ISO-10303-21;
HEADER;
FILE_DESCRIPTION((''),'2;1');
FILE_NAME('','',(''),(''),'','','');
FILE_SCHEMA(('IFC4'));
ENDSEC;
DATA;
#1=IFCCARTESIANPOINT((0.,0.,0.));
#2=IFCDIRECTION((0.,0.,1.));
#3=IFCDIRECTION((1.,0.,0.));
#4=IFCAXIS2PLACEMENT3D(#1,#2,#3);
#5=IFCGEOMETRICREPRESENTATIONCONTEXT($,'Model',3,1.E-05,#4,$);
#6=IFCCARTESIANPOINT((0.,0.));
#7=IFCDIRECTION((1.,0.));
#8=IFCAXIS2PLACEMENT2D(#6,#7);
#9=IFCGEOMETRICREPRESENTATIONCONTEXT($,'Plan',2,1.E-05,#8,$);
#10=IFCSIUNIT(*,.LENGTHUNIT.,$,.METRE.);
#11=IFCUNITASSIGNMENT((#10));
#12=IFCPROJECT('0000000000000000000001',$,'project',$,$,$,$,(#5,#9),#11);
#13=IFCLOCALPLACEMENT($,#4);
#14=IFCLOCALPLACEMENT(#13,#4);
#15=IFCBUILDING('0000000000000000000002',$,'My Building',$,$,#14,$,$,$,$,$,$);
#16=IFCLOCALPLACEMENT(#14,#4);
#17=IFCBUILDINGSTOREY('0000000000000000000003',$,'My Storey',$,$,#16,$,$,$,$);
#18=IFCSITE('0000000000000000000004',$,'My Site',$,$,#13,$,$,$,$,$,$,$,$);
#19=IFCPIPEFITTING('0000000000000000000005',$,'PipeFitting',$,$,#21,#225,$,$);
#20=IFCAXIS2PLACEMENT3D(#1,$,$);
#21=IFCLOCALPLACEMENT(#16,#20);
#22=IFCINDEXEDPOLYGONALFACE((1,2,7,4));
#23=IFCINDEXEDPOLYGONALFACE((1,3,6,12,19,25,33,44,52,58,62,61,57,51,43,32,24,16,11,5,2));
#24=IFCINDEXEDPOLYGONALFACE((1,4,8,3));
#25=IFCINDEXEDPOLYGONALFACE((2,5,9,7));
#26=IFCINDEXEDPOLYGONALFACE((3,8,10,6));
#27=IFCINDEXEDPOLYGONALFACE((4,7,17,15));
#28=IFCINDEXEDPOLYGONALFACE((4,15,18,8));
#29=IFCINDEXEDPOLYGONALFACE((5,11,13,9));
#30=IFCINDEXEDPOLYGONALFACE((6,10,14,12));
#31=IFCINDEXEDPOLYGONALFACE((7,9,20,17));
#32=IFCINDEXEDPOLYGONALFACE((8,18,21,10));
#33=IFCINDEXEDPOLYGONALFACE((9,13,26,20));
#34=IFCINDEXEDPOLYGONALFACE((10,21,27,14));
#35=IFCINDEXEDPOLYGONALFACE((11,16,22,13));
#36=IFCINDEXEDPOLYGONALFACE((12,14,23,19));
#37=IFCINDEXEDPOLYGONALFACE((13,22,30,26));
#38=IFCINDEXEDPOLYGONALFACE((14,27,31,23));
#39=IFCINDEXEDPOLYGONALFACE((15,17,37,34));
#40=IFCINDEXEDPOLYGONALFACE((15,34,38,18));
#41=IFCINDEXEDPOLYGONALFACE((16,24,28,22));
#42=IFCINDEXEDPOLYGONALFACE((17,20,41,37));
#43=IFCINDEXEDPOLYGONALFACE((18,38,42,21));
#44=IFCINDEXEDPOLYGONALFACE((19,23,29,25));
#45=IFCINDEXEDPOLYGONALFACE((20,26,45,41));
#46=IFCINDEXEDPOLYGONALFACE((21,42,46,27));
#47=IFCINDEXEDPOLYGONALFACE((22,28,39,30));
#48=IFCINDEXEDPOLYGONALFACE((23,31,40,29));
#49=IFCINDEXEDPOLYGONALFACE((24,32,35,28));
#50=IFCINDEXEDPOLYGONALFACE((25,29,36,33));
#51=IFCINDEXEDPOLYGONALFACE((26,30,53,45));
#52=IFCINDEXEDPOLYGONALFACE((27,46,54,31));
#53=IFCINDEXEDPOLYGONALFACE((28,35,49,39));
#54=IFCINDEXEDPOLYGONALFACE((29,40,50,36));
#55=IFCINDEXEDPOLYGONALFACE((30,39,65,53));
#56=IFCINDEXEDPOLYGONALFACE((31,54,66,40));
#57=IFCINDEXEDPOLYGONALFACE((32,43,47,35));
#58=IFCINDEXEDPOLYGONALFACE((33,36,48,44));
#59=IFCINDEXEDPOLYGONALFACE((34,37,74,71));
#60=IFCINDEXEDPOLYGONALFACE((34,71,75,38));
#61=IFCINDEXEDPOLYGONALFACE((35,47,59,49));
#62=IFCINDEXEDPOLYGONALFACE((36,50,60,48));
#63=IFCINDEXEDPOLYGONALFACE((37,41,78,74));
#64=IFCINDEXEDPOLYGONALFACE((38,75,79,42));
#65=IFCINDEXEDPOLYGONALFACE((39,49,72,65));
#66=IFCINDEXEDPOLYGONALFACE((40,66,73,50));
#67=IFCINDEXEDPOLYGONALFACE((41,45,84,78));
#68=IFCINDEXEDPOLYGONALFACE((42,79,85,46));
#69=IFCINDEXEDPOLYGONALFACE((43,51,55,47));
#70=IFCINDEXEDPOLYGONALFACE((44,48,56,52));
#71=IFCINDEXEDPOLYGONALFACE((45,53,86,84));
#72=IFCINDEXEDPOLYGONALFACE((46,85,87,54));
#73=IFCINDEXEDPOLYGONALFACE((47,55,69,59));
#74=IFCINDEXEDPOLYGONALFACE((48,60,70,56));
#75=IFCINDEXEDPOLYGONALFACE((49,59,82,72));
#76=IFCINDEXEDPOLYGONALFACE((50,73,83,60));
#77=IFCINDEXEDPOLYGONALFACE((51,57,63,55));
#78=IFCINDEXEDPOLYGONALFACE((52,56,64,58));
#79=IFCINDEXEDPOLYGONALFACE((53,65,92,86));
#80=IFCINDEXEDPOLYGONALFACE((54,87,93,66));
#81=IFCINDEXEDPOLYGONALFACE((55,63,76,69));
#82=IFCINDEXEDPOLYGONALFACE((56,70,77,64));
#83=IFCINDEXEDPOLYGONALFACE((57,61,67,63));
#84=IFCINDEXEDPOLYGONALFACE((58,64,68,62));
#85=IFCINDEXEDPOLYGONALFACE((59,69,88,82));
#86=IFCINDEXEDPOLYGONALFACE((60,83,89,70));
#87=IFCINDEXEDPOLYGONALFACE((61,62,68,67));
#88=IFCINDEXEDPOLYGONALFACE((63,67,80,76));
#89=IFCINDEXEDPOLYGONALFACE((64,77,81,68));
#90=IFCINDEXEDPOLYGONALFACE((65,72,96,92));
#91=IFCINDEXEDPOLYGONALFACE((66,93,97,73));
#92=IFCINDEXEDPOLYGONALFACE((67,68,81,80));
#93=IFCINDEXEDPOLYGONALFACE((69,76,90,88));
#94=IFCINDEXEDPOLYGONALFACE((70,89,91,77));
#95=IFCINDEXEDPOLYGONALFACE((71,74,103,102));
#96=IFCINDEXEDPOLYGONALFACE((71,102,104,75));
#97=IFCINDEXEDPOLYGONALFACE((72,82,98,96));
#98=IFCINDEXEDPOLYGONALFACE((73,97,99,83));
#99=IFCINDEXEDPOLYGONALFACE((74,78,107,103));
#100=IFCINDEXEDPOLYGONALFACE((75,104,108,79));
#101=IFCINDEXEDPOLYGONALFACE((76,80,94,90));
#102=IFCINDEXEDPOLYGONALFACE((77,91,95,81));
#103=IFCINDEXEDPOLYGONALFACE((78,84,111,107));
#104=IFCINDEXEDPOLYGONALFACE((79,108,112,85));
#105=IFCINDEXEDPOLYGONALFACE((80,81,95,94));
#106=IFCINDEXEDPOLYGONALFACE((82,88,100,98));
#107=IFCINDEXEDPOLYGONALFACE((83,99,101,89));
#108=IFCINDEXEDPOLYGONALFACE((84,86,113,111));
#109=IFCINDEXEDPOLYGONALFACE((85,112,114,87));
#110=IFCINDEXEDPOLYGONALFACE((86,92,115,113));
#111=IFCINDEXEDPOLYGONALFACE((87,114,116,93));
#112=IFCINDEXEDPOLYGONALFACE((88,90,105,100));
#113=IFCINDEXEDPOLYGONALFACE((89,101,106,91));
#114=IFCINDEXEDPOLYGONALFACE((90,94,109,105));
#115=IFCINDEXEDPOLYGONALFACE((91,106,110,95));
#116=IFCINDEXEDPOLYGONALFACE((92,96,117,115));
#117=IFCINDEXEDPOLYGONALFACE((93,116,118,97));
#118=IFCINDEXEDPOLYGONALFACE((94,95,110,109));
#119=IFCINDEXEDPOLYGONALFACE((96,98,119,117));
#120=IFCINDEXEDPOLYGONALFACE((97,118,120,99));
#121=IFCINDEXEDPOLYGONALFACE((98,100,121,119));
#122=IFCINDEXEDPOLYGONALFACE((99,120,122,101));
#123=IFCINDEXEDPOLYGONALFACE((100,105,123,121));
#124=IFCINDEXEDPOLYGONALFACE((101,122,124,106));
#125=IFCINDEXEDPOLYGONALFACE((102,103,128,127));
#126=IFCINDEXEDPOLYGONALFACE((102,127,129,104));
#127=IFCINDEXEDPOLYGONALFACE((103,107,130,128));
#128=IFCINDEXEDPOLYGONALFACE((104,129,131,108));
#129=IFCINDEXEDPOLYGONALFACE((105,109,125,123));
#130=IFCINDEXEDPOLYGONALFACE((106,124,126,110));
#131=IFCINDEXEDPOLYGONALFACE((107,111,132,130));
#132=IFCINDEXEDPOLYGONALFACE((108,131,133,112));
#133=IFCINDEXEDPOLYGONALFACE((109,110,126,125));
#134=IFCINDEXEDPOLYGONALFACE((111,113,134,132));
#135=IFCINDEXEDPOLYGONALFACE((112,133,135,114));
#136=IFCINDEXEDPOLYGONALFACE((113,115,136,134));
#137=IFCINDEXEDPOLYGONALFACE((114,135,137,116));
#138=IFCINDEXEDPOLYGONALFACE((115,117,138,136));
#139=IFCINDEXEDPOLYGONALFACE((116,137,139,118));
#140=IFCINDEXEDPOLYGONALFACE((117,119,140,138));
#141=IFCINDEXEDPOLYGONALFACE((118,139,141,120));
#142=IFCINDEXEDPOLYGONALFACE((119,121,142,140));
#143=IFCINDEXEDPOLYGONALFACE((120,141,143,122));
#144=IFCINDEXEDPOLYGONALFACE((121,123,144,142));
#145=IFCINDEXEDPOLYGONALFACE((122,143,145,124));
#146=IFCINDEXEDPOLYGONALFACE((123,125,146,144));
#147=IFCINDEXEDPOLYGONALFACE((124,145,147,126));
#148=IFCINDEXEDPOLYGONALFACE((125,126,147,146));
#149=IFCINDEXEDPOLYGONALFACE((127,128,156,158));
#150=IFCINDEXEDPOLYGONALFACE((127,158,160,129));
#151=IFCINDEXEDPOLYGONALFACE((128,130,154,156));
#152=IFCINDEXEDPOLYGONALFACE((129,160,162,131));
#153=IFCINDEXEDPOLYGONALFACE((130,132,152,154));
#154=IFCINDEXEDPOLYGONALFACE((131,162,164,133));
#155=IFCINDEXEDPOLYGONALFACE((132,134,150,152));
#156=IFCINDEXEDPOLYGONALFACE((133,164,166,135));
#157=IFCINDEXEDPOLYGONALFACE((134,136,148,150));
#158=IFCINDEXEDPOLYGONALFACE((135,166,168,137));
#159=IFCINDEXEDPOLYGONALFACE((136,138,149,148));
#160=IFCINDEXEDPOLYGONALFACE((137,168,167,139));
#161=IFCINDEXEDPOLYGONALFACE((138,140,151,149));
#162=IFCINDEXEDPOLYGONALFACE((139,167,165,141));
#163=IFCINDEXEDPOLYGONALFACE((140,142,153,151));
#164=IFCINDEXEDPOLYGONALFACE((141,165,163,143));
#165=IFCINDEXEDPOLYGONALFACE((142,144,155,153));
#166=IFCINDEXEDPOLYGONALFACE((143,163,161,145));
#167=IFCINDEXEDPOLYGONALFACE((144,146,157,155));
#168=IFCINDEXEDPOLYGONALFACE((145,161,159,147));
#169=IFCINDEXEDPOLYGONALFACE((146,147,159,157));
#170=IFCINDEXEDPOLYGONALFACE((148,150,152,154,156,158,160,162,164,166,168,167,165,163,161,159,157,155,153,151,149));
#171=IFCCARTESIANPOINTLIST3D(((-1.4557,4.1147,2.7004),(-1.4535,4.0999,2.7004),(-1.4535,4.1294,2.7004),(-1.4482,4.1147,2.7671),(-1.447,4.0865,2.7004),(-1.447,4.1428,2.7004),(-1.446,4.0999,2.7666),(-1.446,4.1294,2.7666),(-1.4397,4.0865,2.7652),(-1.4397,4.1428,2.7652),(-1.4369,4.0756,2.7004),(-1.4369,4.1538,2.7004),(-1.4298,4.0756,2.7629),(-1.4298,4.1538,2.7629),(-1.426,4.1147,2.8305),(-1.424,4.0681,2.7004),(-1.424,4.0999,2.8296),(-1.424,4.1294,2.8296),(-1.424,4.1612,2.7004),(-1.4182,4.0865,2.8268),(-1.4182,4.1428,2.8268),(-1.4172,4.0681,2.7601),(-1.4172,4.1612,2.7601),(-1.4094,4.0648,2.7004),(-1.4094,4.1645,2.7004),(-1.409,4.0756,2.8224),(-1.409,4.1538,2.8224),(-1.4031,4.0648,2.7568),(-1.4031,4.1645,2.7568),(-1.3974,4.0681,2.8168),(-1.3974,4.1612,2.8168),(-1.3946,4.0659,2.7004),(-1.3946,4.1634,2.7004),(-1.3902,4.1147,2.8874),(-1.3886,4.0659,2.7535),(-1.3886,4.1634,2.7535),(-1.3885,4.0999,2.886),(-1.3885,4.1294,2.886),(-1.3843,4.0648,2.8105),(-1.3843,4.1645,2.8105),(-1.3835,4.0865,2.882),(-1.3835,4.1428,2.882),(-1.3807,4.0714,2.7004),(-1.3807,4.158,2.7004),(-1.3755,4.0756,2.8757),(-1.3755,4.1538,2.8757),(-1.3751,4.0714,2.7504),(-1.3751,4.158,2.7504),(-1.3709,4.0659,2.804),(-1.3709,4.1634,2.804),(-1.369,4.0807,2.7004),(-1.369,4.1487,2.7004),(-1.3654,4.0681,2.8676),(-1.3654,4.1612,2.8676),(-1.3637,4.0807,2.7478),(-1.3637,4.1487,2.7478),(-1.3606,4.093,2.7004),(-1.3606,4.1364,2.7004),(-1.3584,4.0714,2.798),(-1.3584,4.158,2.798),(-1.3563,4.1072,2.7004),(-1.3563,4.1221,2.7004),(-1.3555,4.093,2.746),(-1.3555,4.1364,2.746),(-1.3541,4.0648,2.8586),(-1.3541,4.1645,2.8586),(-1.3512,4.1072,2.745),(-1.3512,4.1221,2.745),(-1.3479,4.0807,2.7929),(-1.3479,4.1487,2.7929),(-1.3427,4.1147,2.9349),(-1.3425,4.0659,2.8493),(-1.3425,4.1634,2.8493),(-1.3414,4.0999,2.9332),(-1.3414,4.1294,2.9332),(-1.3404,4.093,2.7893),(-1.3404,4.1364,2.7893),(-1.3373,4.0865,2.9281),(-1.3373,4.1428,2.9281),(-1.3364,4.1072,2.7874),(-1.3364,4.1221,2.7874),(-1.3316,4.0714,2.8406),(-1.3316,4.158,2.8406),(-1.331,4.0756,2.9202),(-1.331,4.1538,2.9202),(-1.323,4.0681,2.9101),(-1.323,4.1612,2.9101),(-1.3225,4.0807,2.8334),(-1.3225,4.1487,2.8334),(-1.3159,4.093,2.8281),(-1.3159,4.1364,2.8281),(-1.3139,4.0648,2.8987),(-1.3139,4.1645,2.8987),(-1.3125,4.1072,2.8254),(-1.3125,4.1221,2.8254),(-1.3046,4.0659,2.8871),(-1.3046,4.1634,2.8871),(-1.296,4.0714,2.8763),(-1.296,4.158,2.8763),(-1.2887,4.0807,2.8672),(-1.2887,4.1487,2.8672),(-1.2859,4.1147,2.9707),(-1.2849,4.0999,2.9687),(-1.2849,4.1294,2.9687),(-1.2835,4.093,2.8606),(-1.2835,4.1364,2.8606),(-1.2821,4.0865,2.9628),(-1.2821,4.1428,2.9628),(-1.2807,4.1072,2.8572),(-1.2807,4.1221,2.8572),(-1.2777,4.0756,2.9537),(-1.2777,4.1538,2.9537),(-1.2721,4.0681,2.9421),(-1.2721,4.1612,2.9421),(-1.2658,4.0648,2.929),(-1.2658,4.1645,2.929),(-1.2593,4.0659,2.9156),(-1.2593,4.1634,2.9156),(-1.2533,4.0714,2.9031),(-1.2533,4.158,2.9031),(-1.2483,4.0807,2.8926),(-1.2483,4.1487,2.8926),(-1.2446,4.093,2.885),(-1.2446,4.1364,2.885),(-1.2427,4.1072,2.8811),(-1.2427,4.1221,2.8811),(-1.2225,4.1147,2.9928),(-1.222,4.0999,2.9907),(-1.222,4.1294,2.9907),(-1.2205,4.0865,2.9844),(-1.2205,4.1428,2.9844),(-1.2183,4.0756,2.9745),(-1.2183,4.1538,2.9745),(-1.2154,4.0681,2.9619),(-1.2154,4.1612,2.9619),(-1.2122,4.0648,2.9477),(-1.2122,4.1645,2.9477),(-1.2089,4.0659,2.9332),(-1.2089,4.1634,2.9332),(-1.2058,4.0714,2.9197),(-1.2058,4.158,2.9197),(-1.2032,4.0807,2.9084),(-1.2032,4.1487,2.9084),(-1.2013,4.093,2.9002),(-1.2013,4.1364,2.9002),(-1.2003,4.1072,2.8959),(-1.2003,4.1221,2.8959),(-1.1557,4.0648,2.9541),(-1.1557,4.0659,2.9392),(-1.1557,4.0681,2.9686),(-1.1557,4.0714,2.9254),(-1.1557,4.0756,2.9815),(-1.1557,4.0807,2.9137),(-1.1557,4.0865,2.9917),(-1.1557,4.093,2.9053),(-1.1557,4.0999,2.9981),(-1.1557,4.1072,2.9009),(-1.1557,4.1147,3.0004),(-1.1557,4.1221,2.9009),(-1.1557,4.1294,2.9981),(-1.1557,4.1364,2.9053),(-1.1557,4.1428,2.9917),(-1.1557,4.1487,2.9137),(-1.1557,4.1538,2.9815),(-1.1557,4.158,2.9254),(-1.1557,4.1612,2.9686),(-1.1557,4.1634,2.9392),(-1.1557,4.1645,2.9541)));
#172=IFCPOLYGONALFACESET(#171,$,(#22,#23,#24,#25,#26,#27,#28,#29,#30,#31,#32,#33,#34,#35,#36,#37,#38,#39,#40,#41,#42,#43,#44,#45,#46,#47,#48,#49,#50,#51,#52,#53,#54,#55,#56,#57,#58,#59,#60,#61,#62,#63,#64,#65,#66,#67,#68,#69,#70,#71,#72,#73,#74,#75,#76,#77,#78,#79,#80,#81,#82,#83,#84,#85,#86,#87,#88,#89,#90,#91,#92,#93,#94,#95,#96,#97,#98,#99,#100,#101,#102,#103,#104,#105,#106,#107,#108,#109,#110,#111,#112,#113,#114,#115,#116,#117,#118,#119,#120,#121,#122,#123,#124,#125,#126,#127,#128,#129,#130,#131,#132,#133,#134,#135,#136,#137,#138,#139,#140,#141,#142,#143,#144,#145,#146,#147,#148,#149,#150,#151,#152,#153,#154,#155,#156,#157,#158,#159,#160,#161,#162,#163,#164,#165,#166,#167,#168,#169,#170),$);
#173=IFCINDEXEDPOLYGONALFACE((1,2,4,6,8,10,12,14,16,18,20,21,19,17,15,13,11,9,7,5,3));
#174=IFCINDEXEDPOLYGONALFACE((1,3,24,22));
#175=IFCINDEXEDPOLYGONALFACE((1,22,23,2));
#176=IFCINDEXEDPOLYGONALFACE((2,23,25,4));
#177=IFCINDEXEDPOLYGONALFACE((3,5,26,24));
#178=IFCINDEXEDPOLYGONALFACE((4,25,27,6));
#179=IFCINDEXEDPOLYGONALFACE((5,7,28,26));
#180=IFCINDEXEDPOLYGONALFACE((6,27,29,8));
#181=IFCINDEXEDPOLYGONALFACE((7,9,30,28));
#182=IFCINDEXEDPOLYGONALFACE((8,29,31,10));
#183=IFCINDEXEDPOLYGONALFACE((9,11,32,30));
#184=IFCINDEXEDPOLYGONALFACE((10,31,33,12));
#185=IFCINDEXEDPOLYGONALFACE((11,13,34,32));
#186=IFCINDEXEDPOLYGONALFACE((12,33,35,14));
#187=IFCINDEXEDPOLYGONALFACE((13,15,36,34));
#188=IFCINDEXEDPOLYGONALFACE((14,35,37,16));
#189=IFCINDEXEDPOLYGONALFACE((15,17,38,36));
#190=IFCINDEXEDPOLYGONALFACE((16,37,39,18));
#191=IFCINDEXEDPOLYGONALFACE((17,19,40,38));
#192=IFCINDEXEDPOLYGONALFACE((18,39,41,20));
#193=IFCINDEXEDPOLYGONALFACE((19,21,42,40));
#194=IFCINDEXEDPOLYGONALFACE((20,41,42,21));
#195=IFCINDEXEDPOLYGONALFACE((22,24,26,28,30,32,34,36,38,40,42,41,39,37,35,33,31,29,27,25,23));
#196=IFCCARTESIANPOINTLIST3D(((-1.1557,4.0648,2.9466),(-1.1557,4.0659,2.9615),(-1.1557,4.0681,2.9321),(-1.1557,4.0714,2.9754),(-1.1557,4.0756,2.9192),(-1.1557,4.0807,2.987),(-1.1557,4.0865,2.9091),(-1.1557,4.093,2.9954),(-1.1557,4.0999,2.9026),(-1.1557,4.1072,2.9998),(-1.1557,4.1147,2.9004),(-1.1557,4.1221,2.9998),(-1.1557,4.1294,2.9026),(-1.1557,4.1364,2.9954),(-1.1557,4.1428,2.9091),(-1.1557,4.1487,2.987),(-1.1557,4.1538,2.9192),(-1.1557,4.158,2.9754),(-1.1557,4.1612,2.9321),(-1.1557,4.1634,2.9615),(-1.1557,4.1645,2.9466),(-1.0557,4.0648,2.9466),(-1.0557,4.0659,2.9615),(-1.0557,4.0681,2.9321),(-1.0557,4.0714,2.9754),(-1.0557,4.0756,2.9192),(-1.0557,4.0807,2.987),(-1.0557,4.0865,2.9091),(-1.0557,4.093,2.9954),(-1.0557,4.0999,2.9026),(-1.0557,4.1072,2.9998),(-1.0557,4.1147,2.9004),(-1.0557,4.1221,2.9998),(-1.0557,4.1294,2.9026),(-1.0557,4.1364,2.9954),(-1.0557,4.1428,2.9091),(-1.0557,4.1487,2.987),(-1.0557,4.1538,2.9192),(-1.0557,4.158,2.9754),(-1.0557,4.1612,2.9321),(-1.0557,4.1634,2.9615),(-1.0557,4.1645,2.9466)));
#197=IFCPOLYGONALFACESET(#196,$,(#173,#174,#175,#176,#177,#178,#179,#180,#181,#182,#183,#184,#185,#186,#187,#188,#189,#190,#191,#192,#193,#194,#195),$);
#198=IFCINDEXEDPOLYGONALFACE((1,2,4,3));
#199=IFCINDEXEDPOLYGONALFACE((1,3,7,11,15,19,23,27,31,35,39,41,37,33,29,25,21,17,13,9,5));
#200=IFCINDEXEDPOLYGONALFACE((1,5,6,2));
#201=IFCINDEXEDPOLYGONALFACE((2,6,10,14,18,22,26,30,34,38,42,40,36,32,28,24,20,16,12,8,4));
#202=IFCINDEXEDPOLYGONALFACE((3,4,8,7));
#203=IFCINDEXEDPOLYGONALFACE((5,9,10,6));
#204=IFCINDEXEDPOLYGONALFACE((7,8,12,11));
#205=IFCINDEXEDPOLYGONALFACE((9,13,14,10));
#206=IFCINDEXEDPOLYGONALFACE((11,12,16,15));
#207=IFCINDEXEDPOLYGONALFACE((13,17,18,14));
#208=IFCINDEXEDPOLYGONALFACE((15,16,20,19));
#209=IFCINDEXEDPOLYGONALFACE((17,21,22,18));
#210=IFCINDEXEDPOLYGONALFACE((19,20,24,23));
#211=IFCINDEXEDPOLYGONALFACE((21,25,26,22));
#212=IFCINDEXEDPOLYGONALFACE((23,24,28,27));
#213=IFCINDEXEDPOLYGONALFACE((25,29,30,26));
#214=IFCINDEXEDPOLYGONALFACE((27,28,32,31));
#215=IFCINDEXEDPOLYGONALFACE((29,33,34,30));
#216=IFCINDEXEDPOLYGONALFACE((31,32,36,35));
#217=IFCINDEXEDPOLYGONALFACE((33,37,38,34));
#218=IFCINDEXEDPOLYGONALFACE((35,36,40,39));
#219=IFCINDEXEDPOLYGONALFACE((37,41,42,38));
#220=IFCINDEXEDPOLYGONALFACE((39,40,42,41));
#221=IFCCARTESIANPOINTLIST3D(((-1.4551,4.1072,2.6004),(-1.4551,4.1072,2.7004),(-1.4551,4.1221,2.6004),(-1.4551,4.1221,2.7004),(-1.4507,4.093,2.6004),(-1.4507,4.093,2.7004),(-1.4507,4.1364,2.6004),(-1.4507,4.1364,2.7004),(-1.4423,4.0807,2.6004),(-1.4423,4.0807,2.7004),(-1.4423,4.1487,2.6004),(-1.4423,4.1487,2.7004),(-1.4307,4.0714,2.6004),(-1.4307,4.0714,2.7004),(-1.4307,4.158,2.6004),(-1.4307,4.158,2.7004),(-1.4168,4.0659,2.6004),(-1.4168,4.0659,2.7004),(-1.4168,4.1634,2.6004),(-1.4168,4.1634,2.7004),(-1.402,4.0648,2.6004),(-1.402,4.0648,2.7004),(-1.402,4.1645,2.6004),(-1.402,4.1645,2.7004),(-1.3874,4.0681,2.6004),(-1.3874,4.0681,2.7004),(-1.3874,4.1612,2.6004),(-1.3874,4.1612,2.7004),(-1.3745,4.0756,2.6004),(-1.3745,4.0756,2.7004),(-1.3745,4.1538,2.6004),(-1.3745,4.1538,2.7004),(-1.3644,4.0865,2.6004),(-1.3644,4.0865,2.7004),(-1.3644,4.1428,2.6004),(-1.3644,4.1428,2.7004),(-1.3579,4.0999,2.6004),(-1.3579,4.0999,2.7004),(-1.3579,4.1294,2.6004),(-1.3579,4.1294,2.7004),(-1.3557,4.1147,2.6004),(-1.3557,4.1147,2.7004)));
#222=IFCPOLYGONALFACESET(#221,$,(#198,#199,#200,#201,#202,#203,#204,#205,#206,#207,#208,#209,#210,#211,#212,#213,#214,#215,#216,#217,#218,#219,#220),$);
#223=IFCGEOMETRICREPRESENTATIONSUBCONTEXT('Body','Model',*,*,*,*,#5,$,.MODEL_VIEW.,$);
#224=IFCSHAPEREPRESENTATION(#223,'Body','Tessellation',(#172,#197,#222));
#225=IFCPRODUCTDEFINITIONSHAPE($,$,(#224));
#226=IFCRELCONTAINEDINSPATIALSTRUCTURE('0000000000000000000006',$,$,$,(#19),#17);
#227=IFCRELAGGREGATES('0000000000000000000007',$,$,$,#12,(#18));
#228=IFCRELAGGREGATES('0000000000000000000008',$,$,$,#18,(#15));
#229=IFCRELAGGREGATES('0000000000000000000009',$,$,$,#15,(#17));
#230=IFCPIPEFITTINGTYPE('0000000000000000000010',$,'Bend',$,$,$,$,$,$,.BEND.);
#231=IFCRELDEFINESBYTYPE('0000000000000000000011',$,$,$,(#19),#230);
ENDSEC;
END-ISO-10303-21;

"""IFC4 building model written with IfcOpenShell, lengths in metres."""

from ifc_helpers import new_model, entity, si_unit, frame, origin_with_axes, origin_2d_with_axis, place, context, subcontext, project, spatial, circle, extrude, source, transform, mapped, type_object, type_shapes, element, save


model = new_model("IFC4")

# Units and contexts
model_context = context("Model", 3, precision=1e-05, world=origin_with_axes())
plan_context = context("Plan", 2, precision=1e-05, world=origin_2d_with_axis())
body_context = subcontext(model_context, "Body", "Model", "MODEL_VIEW")
ifc_project = project(units=[si_unit("LENGTHUNIT", "METRE")], contexts=[model_context, plan_context])

# Site, building, storey
site_placement = place(None, origin_with_axes())
site = spatial("IfcSite", under=ifc_project, at=site_placement, Name="My Site")
building_placement = place(site_placement, origin_with_axes())
building = spatial("IfcBuilding", under=site, at=building_placement, Name="My Building")
storey_placement = place(building_placement, origin_with_axes())
storey = spatial("IfcBuildingStorey", under=building, at=storey_placement, Name="My Storey")

# Pipe fitting
pipe_fitting_type = type_object("IfcPipeFittingType", Name="Bend", PredefinedType="BEND")
shared_shape_1 = source(origin_with_axes(), body_context, "Body", "SolidModel", [
    entity("IfcSweptDiskSolid", entity("IfcIndexedPolyCurve", entity("IfcCartesianPointList3D", [[0.0, 0.0, -0.1], [0.0732, 0.0, -0.2768], [0.25, 0.0, -0.35]]), [entity("IfcArcIndex", [1, 2, 3])]), 0.05),
    extrude(circle(Radius=0.05), origin_with_axes(), (0.0, 0.0, -1.0), 0.1),
    extrude(circle(Radius=0.05), frame((0.25, 0.0, -0.35), z_axis=(1.0, 0.0, 0.0), x_axis=(0.0, 0.0, 1.0)), (0.0, 0.0, 1.0), 0.1),
])
type_shapes(pipe_fitting_type, [shared_shape_1])
for number, where, z_axis, x_axis, name in (
    (1, (-1.0557, 4.1147, 2.9504), (1.0, -0.000001, 0.000001), (0.000001, 0.0, -1.0), "PipeFitting"),
):
    element("IfcPipeFitting", number, at=place(storey_placement, frame(where, z_axis=z_axis, x_axis=x_axis)), inside=storey, type_object=pipe_fitting_type, Name=name, context=body_context, shape_type="MappedRepresentation", body=[
        mapped(shared_shape_1, transform((0.0, 0.0, 0.0), x_axis=(1.0, 0.0, 0.0), y_axis=(0.0, 1.0, 0.0), z_axis=(0.0, 0.0, 1.0), scale=1.0)),
    ])

save(model, "model.ifc")
